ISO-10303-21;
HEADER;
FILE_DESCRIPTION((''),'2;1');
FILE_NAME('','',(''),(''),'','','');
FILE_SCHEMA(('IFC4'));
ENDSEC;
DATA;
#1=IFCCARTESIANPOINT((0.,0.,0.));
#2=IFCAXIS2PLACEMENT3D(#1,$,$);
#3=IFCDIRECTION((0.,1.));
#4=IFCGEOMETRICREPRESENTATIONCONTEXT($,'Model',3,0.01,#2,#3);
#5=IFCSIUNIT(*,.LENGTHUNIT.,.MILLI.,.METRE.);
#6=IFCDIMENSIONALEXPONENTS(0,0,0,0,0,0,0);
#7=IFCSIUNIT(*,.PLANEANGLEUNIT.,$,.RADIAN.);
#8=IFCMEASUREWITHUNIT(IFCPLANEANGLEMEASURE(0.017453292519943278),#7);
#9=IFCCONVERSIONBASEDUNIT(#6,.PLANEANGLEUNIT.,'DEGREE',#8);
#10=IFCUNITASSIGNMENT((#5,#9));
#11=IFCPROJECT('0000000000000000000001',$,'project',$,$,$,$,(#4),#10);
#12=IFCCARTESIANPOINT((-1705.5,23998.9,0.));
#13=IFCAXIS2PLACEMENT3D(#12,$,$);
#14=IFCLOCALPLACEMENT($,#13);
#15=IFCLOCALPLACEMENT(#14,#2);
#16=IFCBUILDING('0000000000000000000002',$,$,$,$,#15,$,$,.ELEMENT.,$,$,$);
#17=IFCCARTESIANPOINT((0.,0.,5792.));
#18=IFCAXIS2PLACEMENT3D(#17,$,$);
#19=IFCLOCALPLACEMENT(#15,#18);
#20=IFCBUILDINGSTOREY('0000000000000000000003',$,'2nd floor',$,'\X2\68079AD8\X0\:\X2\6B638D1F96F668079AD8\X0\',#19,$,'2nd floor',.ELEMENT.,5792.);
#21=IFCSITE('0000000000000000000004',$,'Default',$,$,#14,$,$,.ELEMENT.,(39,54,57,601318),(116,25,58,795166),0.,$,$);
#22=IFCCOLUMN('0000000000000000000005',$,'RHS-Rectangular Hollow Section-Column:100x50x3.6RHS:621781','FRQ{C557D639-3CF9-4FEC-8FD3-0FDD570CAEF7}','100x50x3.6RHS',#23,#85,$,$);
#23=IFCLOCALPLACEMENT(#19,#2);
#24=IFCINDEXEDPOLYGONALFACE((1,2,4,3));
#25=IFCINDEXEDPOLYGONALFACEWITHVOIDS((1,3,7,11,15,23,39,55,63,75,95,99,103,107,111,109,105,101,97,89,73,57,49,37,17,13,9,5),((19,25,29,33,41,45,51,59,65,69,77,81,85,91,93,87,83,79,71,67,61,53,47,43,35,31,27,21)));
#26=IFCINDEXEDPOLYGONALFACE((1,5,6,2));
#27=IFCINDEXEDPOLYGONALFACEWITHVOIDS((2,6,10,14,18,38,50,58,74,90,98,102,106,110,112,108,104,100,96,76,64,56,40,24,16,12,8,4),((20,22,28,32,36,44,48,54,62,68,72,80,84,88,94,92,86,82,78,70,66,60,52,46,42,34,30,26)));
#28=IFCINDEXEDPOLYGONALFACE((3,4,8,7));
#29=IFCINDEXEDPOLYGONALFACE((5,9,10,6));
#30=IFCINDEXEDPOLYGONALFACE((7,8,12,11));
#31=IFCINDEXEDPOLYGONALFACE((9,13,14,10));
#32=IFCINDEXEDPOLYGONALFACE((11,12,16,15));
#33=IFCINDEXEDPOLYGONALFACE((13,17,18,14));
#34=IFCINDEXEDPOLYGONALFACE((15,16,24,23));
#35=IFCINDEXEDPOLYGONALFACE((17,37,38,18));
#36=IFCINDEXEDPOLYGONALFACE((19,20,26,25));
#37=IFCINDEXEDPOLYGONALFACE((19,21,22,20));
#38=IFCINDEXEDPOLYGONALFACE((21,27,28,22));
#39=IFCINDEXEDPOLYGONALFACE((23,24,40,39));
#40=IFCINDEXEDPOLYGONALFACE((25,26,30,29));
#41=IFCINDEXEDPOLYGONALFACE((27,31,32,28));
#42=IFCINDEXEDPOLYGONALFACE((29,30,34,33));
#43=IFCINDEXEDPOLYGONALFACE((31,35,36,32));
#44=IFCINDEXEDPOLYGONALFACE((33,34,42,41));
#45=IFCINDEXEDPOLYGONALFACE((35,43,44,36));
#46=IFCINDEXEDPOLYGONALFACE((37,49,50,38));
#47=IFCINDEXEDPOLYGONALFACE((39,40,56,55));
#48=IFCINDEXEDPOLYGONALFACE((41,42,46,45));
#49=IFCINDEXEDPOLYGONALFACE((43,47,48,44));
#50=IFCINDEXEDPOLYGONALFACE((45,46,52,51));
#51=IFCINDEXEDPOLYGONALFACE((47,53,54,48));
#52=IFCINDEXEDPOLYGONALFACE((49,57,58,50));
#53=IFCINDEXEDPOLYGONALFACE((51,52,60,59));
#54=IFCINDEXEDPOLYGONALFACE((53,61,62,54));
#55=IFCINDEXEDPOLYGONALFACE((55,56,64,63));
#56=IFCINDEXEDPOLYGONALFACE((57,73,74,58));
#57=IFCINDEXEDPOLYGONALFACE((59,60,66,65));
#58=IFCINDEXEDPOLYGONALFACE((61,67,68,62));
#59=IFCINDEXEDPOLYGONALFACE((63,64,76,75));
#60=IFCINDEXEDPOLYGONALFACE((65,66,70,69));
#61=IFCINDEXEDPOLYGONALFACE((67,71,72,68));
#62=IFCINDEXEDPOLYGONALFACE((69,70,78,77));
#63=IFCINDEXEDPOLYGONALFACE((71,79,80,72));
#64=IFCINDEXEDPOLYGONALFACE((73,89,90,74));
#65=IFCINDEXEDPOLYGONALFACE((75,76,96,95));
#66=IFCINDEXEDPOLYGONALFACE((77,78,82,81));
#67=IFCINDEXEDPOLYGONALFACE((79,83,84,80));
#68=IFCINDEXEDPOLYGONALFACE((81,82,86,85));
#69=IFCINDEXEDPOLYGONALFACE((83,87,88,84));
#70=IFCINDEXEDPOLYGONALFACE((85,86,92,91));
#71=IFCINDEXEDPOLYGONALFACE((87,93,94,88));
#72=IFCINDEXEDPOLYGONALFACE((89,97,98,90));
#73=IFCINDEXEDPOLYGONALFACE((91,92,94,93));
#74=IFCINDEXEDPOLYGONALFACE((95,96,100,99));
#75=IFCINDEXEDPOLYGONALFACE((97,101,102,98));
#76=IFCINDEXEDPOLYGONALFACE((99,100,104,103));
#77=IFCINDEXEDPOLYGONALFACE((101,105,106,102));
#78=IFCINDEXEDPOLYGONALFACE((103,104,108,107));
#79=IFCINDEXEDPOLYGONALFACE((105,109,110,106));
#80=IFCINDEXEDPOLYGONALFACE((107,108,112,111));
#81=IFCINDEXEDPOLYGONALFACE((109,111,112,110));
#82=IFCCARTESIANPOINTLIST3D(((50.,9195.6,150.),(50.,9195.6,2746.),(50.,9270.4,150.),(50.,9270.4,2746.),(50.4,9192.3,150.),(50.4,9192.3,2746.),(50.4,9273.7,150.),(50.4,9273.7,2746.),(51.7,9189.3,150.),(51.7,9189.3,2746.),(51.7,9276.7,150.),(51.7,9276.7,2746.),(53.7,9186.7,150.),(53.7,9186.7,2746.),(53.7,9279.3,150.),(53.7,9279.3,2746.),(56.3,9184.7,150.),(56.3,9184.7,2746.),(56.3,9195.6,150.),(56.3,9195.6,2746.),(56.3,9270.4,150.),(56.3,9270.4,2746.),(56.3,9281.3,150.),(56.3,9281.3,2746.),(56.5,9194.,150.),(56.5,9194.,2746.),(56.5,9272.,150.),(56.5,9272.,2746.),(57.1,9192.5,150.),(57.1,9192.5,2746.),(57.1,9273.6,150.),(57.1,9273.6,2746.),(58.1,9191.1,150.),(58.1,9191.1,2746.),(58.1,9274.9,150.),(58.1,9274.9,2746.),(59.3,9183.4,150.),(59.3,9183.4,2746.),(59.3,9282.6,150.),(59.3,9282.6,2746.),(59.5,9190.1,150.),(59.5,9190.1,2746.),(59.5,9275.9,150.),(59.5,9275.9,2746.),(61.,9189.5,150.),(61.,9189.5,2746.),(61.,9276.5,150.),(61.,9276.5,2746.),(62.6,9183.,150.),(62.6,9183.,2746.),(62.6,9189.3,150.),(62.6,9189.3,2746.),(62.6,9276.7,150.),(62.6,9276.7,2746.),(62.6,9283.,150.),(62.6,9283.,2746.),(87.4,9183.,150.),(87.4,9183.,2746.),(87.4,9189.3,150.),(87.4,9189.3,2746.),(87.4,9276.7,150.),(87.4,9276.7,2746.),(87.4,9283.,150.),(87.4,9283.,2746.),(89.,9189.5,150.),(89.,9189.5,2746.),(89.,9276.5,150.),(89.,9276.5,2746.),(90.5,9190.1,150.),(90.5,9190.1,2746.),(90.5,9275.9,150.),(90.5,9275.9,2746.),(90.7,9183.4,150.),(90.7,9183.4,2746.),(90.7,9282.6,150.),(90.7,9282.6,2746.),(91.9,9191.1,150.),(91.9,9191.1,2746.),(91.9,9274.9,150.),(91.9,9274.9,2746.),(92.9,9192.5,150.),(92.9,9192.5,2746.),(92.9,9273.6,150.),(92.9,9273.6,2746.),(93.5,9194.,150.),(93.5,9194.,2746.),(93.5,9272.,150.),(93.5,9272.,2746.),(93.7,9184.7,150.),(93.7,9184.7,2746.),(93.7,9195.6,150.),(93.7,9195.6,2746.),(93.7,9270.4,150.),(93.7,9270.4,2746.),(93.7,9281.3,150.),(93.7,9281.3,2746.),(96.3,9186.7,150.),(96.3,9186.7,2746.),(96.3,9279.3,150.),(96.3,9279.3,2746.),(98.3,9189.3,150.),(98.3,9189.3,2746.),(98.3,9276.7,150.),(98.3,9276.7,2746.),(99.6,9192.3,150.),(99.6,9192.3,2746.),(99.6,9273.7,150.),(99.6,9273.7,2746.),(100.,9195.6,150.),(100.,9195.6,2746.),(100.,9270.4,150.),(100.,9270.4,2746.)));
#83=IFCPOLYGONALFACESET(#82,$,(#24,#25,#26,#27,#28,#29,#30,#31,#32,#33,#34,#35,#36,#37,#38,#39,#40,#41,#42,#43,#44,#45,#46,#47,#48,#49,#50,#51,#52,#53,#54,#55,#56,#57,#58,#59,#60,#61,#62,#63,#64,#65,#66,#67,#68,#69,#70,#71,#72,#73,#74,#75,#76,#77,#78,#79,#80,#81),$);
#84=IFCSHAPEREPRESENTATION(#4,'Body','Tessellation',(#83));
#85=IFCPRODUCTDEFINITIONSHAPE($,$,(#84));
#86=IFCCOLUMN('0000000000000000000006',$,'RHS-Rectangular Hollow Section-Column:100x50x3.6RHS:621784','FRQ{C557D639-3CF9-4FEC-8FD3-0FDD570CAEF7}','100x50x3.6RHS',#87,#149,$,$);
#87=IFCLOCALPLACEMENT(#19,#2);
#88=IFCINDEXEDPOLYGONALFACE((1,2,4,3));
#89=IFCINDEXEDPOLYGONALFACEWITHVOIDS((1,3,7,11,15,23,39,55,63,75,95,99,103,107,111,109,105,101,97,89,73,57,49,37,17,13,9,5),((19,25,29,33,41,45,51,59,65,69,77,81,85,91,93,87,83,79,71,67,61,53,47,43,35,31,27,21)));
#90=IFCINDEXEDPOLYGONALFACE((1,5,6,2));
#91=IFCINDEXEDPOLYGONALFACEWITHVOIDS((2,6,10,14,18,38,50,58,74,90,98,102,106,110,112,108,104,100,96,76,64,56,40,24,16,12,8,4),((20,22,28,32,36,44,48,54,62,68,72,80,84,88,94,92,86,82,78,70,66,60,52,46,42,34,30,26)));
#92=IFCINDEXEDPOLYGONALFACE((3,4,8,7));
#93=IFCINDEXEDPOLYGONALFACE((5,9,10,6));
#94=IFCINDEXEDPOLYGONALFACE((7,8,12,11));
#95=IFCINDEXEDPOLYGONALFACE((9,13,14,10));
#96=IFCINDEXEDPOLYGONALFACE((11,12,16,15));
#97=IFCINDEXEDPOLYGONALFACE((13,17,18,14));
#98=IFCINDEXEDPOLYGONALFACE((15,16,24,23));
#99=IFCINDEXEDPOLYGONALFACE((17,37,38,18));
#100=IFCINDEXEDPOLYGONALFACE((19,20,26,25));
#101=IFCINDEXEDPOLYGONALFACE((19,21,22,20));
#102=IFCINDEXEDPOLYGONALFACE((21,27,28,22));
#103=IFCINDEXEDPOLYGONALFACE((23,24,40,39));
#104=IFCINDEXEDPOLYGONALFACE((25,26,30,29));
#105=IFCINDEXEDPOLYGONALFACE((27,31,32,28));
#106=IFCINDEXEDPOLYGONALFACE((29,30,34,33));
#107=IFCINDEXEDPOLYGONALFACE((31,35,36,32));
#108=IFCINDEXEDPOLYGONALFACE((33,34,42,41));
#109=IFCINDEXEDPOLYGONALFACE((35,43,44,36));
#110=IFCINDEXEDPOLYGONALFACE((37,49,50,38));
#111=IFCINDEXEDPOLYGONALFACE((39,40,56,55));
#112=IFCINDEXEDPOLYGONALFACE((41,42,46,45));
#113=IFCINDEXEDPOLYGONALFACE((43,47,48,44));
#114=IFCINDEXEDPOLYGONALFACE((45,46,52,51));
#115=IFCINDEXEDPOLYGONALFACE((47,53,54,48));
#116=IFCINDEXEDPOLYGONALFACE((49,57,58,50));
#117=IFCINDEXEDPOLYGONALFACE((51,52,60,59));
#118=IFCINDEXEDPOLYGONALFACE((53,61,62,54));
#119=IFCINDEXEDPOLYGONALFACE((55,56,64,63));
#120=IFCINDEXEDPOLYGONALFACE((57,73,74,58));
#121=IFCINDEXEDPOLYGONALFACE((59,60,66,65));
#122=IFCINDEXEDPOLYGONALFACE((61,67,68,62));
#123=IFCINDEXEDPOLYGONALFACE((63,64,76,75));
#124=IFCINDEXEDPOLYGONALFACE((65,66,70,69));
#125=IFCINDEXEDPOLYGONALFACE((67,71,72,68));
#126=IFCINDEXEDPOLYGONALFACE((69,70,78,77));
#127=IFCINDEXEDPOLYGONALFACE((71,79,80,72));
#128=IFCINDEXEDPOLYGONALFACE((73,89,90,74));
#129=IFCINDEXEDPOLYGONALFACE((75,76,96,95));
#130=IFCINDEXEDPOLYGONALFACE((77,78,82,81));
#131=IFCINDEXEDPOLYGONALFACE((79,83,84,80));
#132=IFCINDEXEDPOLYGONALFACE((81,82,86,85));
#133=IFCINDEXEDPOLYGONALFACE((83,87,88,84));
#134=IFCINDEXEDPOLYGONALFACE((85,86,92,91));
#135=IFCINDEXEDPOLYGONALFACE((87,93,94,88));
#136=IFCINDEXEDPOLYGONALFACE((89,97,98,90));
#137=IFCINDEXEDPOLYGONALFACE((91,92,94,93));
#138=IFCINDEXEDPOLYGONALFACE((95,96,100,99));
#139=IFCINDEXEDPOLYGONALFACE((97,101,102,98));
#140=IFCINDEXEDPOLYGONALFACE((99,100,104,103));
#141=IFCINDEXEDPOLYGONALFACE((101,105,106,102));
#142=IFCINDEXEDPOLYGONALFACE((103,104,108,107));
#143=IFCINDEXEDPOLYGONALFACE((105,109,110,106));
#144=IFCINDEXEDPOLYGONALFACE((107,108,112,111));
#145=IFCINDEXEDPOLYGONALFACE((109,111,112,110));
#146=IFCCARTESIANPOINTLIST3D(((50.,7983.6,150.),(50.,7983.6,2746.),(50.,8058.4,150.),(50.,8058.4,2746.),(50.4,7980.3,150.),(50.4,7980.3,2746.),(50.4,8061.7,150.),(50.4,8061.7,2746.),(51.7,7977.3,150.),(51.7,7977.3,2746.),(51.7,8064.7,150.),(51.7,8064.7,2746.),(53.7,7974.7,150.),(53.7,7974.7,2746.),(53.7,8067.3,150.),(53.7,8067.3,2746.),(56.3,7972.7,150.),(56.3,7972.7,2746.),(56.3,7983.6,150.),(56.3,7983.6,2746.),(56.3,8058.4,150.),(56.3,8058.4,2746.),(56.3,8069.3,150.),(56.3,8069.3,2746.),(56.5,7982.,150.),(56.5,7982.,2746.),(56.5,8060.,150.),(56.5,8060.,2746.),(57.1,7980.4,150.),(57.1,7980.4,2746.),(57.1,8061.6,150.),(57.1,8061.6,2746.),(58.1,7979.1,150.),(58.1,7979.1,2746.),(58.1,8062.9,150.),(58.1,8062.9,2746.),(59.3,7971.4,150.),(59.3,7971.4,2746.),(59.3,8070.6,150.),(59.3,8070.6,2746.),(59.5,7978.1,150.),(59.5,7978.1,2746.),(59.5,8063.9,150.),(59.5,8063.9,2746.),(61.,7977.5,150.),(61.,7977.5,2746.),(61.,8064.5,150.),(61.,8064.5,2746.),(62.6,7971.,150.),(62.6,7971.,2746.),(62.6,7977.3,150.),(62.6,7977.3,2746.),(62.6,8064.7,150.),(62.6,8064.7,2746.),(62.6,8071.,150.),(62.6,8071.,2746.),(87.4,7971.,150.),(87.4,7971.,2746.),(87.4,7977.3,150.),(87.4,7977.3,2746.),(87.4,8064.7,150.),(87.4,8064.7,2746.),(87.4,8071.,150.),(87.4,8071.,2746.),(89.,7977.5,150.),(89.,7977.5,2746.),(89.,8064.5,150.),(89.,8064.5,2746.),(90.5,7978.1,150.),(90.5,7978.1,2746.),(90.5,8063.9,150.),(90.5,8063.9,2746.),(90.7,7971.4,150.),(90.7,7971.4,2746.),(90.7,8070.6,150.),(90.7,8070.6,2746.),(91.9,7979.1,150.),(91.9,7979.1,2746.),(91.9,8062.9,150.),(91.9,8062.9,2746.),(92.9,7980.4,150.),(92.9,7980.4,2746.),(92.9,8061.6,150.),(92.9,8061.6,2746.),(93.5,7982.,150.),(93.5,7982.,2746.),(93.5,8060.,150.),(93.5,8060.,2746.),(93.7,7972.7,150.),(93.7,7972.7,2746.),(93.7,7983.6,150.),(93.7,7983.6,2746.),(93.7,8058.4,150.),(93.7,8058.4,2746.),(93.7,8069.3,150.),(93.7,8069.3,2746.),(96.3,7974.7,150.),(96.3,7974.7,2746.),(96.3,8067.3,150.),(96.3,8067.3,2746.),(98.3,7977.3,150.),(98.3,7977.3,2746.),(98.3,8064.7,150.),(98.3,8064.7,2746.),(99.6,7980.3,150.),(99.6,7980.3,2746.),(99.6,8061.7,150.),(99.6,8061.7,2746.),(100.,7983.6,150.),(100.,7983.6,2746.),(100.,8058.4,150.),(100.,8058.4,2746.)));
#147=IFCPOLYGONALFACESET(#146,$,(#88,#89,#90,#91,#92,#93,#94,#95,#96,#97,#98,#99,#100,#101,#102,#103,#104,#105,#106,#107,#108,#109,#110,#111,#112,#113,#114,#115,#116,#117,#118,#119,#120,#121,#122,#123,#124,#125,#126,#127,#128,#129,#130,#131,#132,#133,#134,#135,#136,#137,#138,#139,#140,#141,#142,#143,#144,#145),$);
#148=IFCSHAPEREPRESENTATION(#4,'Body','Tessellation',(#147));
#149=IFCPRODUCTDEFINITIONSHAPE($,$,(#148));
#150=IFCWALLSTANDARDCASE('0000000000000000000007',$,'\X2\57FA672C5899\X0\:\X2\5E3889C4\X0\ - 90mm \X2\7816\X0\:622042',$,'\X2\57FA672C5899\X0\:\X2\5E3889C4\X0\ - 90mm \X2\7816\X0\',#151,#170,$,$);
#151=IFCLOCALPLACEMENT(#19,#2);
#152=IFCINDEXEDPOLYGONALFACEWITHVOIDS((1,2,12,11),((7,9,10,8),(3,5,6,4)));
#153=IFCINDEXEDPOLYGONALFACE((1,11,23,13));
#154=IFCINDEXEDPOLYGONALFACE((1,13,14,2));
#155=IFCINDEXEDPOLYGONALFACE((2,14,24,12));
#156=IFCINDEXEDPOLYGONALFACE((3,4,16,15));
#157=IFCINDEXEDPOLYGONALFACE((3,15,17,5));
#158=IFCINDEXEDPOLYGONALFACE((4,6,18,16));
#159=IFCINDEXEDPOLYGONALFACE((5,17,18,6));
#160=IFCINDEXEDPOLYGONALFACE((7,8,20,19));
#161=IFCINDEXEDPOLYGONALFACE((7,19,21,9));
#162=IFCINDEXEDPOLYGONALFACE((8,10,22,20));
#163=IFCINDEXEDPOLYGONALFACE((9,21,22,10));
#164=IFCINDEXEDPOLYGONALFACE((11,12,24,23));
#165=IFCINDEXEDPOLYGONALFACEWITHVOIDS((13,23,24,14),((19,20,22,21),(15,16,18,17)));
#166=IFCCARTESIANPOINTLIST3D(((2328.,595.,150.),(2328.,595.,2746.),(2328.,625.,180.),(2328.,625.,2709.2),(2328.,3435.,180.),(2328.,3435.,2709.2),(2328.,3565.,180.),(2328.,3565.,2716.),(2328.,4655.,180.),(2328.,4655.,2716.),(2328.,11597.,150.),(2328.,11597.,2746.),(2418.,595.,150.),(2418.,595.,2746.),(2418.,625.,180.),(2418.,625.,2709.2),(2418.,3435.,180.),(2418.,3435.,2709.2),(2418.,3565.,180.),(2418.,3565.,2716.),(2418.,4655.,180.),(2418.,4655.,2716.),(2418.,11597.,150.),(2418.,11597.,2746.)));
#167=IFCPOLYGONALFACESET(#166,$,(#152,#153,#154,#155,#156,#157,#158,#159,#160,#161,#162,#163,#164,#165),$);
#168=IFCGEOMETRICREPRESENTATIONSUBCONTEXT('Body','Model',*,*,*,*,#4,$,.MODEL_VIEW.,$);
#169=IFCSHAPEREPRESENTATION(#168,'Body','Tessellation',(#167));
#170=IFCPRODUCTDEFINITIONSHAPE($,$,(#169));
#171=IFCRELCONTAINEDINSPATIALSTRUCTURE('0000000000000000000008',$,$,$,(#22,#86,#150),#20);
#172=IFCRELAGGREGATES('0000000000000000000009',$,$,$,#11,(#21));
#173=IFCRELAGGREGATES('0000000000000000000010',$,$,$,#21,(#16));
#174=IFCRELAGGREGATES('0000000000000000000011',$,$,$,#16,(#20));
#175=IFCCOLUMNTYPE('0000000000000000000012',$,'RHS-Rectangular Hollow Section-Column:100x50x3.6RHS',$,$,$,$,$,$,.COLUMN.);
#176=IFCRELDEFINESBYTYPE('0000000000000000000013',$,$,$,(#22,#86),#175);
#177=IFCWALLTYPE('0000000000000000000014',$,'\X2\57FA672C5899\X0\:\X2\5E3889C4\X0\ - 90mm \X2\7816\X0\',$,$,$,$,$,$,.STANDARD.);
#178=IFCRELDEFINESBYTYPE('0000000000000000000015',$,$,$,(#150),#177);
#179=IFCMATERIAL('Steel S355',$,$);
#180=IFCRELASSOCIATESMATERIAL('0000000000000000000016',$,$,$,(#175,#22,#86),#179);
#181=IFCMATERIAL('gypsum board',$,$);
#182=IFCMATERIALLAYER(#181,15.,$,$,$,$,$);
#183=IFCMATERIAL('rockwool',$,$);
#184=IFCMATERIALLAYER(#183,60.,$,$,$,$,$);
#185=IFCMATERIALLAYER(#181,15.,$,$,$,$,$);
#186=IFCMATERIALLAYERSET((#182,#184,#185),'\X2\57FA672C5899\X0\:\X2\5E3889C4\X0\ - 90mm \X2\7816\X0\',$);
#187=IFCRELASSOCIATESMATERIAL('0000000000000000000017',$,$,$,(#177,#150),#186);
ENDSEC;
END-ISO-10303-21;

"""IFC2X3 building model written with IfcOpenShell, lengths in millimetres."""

from ifc_helpers import new_model, entity, si_unit, converted_unit, direction, frame, frame_2d, origin, origin_2d, place, context, subcontext, project, spatial, rectangle, hollow_rectangle, extrude, clip, halfspace, material, layer, layer_set, layer_usage, type_object, element, save


model = new_model("IFC2X3")

# Units and contexts
model_context = context("Model", 3, precision=0.01, world=origin(), true_north=direction((0.0, 1.0)))
body_context = subcontext(model_context, "Body", "Model", "MODEL_VIEW")
ifc_project = project(units=[si_unit("LENGTHUNIT", "METRE", prefix="MILLI"), converted_unit("PLANEANGLEUNIT", "DEGREE", entity("IfcPlaneAngleMeasure", 0.017453292519943278), si_unit("PLANEANGLEUNIT", "RADIAN"), dimensions=[0, 0, 0, 0, 0, 0, 0])], contexts=[model_context])

# Site, building, storey
site_placement = place(None, frame((-1705.5, 23998.9, 0.0)))
site = spatial("IfcSite", under=ifc_project, at=site_placement, Name="Default", CompositionType="ELEMENT", RefLatitude=(39, 54, 57, 601318), RefLongitude=(116, 25, 58, 795166), RefElevation=0.0)
building_placement = place(site_placement, origin())
building = spatial("IfcBuilding", under=site, at=building_placement, CompositionType="ELEMENT")
storey_placement = place(building_placement, frame((0.0, 0.0, 5792.0)))
storey = spatial("IfcBuildingStorey", under=building, at=storey_placement, Name="2nd floor", ObjectType="标高:正负零标高", LongName="2nd floor", CompositionType="ELEMENT", Elevation=5792.0)

# Columns
ifc_material_1 = material(Name="Steel S355")
column_type = type_object("IfcColumnType", Name="RHS-Rectangular Hollow Section-Column:100x50x3.6RHS", PredefinedType="COLUMN", material=ifc_material_1)
column_1_placement = place(storey_placement, frame((75.0, 9233.0, 2746.0), z_axis=(0.0, 0.0, 1.0), x_axis=(-1.0, 0.0, 0.0)))
element("IfcColumn", 1, at=column_1_placement, inside=storey, type_object=column_type, material=ifc_material_1, Name="RHS-Rectangular Hollow Section-Column:100x50x3.6RHS:621781", Description="FRQ{C557D639-3CF9-4FEC-8FD3-0FDD570CAEF7}", ObjectType="100x50x3.6RHS", context=model_context, shape_type="Clipping", body=[
    clip(extrude(hollow_rectangle(XDim=50.0, YDim=100.0, WallThickness=6.3, InnerFilletRadius=6.3, OuterFilletRadius=12.6, at=origin_2d()), origin(), (0.0, 0.0, -1.0), 2651.9), halfspace(frame((75.0, 9233.0, -2596.0), z_axis=(0.0, 0.0, 1.0), x_axis=(-1.0, 0.0, 0.0)), True)),
])
column_2_placement = place(storey_placement, frame((75.0, 8021.0, 2746.0), z_axis=(0.0, 0.0, 1.0), x_axis=(-1.0, 0.0, 0.0)))
element("IfcColumn", 2, at=column_2_placement, inside=storey, type_object=column_type, material=ifc_material_1, Name="RHS-Rectangular Hollow Section-Column:100x50x3.6RHS:621784", Description="FRQ{C557D639-3CF9-4FEC-8FD3-0FDD570CAEF7}", ObjectType="100x50x3.6RHS", context=model_context, shape_type="Clipping", body=[
    clip(extrude(hollow_rectangle(XDim=50.0, YDim=100.0, WallThickness=6.3, InnerFilletRadius=6.3, OuterFilletRadius=12.6, at=origin_2d()), origin(), (0.0, 0.0, -1.0), 2651.9), halfspace(frame((75.0, 8021.0, -2596.0), z_axis=(0.0, 0.0, 1.0), x_axis=(-1.0, 0.0, 0.0)), True)),
])

# Wall, openings
ifc_material_2 = material(Name="gypsum board")
ifc_layer_1 = layer(ifc_material_2, 15.0)
ifc_material_3 = material(Name="rockwool")
ifc_layer_2 = layer(ifc_material_3, 60.0)
ifc_layer_3 = layer(ifc_material_2, 15.0)
ifc_layer_set = layer_set([ifc_layer_1, ifc_layer_2, ifc_layer_3], Name="基本墙:常规 - 90mm 砖")
ifc_layer_usage = layer_usage(ifc_layer_set, "AXIS2", "NEGATIVE", 45.0)
wall_type = type_object("IfcWallType", Name="基本墙:常规 - 90mm 砖", PredefinedType="STANDARD", material=ifc_layer_set)
wall_placement = place(storey_placement, frame((2373.0, 11597.0, 150.0), z_axis=(0.0, 0.0, 1.0), x_axis=(0.0, -1.0, 0.0)))
wall = element("IfcWallStandardCase", 3, at=wall_placement, inside=storey, type_object=wall_type, material=ifc_layer_usage, Name="基本墙:常规 - 90mm 砖:622042", ObjectType="基本墙:常规 - 90mm 砖", context=body_context, shape_type="SweptSolid", body=[
    extrude(rectangle(XDim=11002.0, YDim=90.0, at=frame_2d((5501.0, 0.0), x_axis=(-1.0, 0.0))), origin(), (0.0, 0.0, 1.0), 2596.0),
])
opening_1_placement = place(wall_placement, origin())
element("IfcOpeningElement", 4, at=opening_1_placement, cuts=wall, ObjectType="Opening", context=body_context, shape_type="SweptSolid", body=[
    extrude(rectangle(XDim=2536.0, YDim=1090.0, at=frame_2d((0.0, 0.0), x_axis=(0.0, 1.0))), frame((7487.0, 45.0, 1298.0), z_axis=(0.0, -1.0, 0.0), x_axis=(-1.0, 0.0, 0.0)), (0.0, 0.0, 1.0), 90.0),
])
opening_2_placement = place(wall_placement, origin())
element("IfcOpeningElement", 5, at=opening_2_placement, cuts=wall, ObjectType="Opening", context=body_context, shape_type="SweptSolid", body=[
    extrude(rectangle(XDim=2529.2, YDim=2810.0, at=frame_2d((0.0, 0.0), x_axis=(0.0, 1.0))), frame((9567.0, 45.0, 1294.6), z_axis=(0.0, -1.0, 0.0), x_axis=(-1.0, 0.0, 0.0)), (0.0, 0.0, 1.0), 90.0),
])

save(model, "model.ifc")
